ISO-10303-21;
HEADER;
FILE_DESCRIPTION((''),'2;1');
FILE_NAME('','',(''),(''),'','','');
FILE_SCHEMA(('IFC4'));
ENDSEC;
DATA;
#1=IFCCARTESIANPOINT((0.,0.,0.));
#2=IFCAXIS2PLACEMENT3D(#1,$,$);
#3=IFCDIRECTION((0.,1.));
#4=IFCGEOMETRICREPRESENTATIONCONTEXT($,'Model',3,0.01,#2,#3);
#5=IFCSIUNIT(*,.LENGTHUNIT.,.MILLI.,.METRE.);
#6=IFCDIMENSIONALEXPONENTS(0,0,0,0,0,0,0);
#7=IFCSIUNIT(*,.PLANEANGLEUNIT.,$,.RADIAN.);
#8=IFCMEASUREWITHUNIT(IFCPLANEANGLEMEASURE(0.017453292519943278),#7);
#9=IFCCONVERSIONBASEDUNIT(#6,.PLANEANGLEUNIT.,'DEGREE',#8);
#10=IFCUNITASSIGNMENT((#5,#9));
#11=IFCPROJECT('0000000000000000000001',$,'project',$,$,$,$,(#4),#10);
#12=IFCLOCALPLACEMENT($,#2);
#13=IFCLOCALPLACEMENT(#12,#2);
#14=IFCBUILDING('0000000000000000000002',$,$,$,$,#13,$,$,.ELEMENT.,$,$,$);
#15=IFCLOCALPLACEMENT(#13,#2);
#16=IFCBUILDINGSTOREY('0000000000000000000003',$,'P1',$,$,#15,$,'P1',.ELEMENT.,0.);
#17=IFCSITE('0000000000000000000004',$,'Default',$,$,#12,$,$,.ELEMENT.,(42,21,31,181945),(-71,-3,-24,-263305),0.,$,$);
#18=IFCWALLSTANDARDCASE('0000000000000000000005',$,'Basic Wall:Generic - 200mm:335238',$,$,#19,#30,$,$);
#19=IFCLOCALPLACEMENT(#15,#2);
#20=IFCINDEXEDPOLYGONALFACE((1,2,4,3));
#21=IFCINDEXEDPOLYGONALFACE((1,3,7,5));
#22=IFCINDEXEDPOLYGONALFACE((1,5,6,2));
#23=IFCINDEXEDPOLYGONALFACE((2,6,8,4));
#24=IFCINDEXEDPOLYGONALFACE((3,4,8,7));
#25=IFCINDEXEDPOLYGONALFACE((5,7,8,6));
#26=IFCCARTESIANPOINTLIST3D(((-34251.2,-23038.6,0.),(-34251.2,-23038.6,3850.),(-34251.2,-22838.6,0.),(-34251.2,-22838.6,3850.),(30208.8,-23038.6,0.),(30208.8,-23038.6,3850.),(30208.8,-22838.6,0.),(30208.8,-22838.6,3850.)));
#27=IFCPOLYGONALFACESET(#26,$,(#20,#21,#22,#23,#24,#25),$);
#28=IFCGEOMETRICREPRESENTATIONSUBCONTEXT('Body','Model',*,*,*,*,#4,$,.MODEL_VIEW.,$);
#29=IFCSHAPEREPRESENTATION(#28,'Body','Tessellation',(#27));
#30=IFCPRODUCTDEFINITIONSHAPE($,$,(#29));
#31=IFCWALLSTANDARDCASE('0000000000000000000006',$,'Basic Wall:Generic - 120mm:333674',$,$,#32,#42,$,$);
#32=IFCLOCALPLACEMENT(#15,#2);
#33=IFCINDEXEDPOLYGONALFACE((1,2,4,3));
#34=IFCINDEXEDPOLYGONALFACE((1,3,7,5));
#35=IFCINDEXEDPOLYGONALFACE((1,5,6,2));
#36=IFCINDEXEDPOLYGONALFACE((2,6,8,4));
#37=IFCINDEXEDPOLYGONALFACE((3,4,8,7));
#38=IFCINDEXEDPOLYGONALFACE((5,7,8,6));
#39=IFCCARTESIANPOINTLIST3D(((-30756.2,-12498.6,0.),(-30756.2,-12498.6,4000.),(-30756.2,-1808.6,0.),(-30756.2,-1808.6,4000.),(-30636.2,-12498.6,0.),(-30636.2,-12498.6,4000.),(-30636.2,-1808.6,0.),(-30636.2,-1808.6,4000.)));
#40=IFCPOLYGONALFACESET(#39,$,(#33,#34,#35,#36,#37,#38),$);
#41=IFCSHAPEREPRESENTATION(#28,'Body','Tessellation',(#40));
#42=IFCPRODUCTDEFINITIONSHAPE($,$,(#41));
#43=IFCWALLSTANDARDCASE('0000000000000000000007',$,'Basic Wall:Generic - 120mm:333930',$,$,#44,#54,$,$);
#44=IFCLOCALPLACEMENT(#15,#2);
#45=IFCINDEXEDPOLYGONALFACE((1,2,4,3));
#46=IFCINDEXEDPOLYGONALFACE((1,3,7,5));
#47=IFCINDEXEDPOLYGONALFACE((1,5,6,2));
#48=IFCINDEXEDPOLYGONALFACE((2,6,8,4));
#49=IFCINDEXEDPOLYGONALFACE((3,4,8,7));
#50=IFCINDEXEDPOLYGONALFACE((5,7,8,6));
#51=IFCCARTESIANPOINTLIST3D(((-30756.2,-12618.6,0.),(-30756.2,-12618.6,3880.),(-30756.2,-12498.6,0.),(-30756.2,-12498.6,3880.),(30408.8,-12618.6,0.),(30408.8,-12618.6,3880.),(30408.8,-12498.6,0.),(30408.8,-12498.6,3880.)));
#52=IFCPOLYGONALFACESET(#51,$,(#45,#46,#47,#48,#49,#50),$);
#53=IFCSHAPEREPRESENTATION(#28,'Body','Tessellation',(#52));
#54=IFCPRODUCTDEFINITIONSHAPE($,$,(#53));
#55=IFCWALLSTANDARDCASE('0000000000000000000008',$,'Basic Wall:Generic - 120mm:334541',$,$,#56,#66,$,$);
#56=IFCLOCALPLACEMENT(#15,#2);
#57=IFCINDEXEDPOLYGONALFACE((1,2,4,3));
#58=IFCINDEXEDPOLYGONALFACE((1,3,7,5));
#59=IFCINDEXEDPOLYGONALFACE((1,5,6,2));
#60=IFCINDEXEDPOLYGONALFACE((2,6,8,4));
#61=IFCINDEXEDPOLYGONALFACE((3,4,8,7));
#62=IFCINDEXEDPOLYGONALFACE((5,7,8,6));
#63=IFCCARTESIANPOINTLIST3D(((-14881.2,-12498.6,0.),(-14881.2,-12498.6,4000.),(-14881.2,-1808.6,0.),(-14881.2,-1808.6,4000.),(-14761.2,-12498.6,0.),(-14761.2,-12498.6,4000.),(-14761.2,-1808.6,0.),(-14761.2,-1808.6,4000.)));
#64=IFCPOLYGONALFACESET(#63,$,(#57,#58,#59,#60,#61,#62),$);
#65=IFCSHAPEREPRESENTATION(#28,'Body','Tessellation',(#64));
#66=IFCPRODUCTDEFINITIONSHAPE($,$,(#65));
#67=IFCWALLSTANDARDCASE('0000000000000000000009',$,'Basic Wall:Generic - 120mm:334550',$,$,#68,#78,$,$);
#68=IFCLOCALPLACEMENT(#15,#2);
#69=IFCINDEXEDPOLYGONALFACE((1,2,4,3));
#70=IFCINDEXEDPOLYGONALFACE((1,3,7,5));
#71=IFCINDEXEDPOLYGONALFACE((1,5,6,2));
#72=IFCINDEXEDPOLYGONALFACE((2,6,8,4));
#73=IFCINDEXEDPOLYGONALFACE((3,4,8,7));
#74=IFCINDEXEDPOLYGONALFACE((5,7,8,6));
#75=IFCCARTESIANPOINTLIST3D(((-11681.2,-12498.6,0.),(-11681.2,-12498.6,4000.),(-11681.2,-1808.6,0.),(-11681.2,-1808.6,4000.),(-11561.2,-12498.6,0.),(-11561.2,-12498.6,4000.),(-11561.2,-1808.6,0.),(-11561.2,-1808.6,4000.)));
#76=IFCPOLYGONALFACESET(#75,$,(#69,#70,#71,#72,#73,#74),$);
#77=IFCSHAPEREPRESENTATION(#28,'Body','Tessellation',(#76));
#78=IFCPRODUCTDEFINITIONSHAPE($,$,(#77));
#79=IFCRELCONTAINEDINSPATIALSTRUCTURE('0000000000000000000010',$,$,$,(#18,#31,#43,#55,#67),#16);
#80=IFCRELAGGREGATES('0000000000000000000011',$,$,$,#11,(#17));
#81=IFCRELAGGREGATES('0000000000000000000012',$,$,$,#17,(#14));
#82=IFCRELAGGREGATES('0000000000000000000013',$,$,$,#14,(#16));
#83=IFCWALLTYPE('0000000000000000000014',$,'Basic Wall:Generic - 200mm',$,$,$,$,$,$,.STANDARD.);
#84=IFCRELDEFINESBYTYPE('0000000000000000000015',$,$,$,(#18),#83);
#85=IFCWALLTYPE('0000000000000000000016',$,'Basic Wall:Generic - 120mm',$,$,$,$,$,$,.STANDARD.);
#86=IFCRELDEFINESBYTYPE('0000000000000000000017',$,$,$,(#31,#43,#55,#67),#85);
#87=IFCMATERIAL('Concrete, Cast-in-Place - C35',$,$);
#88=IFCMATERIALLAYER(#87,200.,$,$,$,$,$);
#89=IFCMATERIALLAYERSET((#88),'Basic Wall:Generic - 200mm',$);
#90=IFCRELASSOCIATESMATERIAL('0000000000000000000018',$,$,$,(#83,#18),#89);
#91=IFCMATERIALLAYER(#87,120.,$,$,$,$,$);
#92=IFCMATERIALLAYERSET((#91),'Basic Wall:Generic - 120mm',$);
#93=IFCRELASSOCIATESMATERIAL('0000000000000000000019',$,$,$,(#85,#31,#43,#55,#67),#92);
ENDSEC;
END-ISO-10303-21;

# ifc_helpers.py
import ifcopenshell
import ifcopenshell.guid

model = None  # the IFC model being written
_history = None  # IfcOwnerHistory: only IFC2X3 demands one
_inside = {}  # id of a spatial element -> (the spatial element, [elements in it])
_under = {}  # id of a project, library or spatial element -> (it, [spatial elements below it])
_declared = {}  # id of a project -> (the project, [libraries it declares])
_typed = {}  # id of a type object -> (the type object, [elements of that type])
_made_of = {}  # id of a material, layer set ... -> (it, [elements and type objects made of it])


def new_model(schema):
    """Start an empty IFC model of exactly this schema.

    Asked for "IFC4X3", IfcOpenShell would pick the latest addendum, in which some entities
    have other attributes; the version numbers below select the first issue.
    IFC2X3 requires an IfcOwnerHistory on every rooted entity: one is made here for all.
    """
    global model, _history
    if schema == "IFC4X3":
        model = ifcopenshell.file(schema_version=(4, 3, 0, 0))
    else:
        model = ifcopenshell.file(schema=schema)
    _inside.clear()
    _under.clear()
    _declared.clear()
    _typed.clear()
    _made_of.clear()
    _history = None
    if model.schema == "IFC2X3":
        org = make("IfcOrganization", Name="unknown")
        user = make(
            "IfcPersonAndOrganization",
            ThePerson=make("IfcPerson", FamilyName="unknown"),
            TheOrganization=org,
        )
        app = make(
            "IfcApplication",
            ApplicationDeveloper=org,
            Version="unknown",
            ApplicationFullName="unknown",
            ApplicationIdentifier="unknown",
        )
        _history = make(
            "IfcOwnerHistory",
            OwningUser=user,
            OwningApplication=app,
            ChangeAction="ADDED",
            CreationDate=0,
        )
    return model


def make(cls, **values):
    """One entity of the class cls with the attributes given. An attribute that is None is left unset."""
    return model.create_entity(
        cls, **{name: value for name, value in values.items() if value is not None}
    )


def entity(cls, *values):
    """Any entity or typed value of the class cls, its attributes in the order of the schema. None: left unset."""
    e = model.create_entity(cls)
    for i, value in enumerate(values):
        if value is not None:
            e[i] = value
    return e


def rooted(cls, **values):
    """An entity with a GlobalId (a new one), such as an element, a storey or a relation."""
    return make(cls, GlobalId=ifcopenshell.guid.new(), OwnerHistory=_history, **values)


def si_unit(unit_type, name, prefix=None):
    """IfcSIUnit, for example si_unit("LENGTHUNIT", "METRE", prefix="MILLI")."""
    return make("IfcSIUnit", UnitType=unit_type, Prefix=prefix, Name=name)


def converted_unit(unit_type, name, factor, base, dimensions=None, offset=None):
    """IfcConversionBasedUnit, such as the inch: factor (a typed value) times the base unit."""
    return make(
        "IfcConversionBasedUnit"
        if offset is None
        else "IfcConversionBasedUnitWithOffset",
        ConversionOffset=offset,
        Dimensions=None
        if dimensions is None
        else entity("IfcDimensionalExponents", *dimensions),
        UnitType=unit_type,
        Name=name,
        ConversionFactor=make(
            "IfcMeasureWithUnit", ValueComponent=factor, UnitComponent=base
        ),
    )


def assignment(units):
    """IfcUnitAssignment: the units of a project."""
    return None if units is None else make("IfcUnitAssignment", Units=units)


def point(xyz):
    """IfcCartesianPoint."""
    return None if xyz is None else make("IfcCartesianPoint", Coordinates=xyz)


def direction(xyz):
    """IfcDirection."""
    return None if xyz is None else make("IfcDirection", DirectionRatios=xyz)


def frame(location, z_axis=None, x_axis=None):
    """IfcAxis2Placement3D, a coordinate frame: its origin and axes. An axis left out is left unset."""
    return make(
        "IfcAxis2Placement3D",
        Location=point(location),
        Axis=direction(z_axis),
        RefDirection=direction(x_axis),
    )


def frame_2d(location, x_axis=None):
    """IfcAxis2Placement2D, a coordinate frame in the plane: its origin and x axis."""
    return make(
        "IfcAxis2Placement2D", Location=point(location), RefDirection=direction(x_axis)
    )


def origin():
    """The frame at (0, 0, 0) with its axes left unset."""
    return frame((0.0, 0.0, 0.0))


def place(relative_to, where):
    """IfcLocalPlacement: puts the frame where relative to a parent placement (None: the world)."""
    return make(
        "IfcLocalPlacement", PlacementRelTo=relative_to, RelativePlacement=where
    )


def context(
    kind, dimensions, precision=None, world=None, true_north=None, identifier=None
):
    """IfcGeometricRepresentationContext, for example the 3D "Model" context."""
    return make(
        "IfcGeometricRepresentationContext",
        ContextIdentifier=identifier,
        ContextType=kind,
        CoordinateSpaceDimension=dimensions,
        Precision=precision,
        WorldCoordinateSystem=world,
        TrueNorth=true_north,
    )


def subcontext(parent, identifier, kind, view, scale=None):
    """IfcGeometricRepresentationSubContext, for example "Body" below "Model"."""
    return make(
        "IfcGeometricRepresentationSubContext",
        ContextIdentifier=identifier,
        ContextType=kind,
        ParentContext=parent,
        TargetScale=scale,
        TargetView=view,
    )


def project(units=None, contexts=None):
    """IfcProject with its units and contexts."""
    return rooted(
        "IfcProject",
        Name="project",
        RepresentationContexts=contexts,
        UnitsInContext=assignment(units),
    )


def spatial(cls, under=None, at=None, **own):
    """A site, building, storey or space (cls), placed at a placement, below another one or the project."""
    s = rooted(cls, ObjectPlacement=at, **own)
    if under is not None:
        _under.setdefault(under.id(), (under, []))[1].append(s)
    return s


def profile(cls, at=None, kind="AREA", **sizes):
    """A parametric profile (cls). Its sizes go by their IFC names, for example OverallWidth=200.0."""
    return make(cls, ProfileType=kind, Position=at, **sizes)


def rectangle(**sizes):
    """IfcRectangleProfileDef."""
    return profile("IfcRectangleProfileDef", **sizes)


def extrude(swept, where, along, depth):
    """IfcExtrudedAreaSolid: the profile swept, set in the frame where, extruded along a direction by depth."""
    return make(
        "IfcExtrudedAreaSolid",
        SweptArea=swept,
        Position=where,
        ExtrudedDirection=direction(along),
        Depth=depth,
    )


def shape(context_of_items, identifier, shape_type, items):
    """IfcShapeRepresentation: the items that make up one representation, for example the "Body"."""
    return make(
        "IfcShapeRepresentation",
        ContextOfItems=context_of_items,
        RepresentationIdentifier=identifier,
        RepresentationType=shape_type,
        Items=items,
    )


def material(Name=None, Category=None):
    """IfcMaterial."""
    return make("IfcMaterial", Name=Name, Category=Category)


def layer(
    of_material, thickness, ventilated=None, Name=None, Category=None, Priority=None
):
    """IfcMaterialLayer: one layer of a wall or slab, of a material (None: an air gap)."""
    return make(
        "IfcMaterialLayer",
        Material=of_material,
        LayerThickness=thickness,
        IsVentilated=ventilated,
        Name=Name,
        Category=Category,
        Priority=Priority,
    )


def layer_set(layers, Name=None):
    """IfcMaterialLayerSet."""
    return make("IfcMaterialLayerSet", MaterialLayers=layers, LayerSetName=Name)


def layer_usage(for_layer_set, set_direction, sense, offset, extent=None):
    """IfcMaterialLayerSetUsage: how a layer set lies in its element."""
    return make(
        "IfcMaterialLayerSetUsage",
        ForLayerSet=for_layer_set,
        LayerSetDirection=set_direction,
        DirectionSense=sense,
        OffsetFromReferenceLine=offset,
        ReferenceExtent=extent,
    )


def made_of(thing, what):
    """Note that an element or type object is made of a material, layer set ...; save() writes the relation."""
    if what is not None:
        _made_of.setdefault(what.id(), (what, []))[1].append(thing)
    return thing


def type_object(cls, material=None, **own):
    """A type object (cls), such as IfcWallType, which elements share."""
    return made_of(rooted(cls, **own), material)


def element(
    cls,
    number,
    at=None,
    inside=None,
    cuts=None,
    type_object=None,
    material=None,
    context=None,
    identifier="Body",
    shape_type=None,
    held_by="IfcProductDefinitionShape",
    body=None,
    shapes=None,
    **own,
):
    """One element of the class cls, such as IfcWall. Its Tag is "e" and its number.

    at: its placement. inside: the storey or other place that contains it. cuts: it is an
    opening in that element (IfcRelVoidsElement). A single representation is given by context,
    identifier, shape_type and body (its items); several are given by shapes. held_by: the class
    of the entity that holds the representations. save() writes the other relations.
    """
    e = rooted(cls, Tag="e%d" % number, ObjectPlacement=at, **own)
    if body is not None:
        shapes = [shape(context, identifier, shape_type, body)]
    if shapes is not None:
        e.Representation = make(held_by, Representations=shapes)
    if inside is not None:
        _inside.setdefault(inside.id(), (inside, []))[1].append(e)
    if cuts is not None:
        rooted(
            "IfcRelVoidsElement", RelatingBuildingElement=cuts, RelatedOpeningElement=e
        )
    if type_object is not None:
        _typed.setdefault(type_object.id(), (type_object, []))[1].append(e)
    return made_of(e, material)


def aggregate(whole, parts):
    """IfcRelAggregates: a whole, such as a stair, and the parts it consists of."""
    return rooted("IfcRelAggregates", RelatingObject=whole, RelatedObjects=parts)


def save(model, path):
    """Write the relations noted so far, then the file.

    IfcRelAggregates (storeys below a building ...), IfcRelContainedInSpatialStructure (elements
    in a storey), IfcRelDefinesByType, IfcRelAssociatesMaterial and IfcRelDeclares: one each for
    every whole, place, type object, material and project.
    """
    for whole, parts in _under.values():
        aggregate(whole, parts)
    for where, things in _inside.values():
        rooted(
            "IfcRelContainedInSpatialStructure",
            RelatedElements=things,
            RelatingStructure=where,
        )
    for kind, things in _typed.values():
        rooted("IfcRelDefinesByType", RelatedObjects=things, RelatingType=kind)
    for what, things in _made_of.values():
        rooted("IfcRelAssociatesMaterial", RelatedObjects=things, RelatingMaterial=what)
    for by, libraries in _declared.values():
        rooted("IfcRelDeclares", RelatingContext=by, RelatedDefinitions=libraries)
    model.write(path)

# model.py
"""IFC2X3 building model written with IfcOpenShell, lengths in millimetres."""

from ifc_helpers import new_model, entity, si_unit, converted_unit, direction, frame, frame_2d, origin, place, context, subcontext, project, spatial, rectangle, extrude, material, layer, layer_set, layer_usage, type_object, element, save


model = new_model("IFC2X3")

# Units and contexts
model_context = context("Model", 3, precision=0.01, world=origin(), true_north=direction((0.0, 1.0)))
body_context = subcontext(model_context, "Body", "Model", "MODEL_VIEW")
ifc_project = project(units=[si_unit("LENGTHUNIT", "METRE", prefix="MILLI"), converted_unit("PLANEANGLEUNIT", "DEGREE", entity("IfcPlaneAngleMeasure", 0.017453292519943278), si_unit("PLANEANGLEUNIT", "RADIAN"), dimensions=[0, 0, 0, 0, 0, 0, 0])], contexts=[model_context])

# Site, building, storey
site_placement = place(None, origin())
site = spatial("IfcSite", under=ifc_project, at=site_placement, Name="Default", CompositionType="ELEMENT", RefLatitude=(42, 21, 31, 181945), RefLongitude=(-71, -3, -24, -263305), RefElevation=0.0)
building_placement = place(site_placement, origin())
building = spatial("IfcBuilding", under=site, at=building_placement, CompositionType="ELEMENT")
storey_placement = place(building_placement, origin())
storey = spatial("IfcBuildingStorey", under=building, at=storey_placement, Name="P1", LongName="P1", CompositionType="ELEMENT", Elevation=0.0)

# Shared definitions
ifc_material = material(Name="Concrete, Cast-in-Place - C35")

# Walls
ifc_layer_1 = layer(ifc_material, 200.0)
ifc_layer_set_1 = layer_set([ifc_layer_1], Name="Basic Wall:Generic - 200mm")
ifc_layer_usage_1 = layer_usage(ifc_layer_set_1, "AXIS2", "NEGATIVE", 100.0)
wall_type_1 = type_object("IfcWallType", Name="Basic Wall:Generic - 200mm", PredefinedType="STANDARD", material=ifc_layer_set_1)
wall_1_placement = place(storey_placement, frame((-34251.2, -22938.6, 0.0)))
element("IfcWallStandardCase", 1, at=wall_1_placement, inside=storey, type_object=wall_type_1, material=ifc_layer_usage_1, Name="Basic Wall:Generic - 200mm:335238", context=body_context, shape_type="SweptSolid", body=[
    extrude(rectangle(XDim=64460.0, YDim=200.0, at=frame_2d((32230.0, 0.0), x_axis=(-1.0, 0.0))), origin(), (0.0, 0.0, 1.0), 3850.0),
])
ifc_layer_2 = layer(ifc_material, 120.0)
ifc_layer_set_2 = layer_set([ifc_layer_2], Name="Basic Wall:Generic - 120mm")
ifc_layer_usage_2 = layer_usage(ifc_layer_set_2, "AXIS2", "NEGATIVE", 60.0)
wall_type_2 = type_object("IfcWallType", Name="Basic Wall:Generic - 120mm", PredefinedType="STANDARD", material=ifc_layer_set_2)
wall_2_placement = place(storey_placement, frame((-30696.2, -1808.6, 0.0), z_axis=(0.0, 0.0, 1.0), x_axis=(0.0, -1.0, 0.0)))
element("IfcWallStandardCase", 2, at=wall_2_placement, inside=storey, type_object=wall_type_2, material=ifc_layer_usage_2, Name="Basic Wall:Generic - 120mm:333674", context=body_context, shape_type="SweptSolid", body=[
    extrude(rectangle(XDim=10690.0, YDim=120.0, at=frame_2d((5345.0, 0.0), x_axis=(-1.0, 0.0))), origin(), (0.0, 0.0, 1.0), 4000.0),
])
ifc_layer_usage_3 = layer_usage(ifc_layer_set_2, "AXIS2", "NEGATIVE", 60.0)
wall_3_placement = place(storey_placement, frame((-30756.2, -12558.6, 0.0)))
element("IfcWallStandardCase", 3, at=wall_3_placement, inside=storey, type_object=wall_type_2, material=ifc_layer_usage_3, Name="Basic Wall:Generic - 120mm:333930", context=body_context, shape_type="SweptSolid", body=[
    extrude(rectangle(XDim=61165.0, YDim=120.0, at=frame_2d((30582.5, 0.0), x_axis=(-1.0, 0.0))), origin(), (0.0, 0.0, 1.0), 3880.0),
])
ifc_layer_usage_4 = layer_usage(ifc_layer_set_2, "AXIS2", "NEGATIVE", 60.0)
wall_4_placement = place(storey_placement, frame((-14821.2, -1808.6, 0.0), z_axis=(0.0, 0.0, 1.0), x_axis=(0.0, -1.0, 0.0)))
element("IfcWallStandardCase", 4, at=wall_4_placement, inside=storey, type_object=wall_type_2, material=ifc_layer_usage_4, Name="Basic Wall:Generic - 120mm:334541", context=body_context, shape_type="SweptSolid", body=[
    extrude(rectangle(XDim=10690.0, YDim=120.0, at=frame_2d((5345.0, 0.0), x_axis=(-1.0, 0.0))), origin(), (0.0, 0.0, 1.0), 4000.0),
])
ifc_layer_usage_5 = layer_usage(ifc_layer_set_2, "AXIS2", "NEGATIVE", 60.0)
wall_5_placement = place(storey_placement, frame((-11621.2, -1808.6, 0.0), z_axis=(0.0, 0.0, 1.0), x_axis=(0.0, -1.0, 0.0)))
element("IfcWallStandardCase", 5, at=wall_5_placement, inside=storey, type_object=wall_type_2, material=ifc_layer_usage_5, Name="Basic Wall:Generic - 120mm:334550", context=body_context, shape_type="SweptSolid", body=[
    extrude(rectangle(XDim=10690.0, YDim=120.0, at=frame_2d((5345.0, 0.0), x_axis=(-1.0, 0.0))), origin(), (0.0, 0.0, 1.0), 4000.0),
])

save(model, "model.ifc")
